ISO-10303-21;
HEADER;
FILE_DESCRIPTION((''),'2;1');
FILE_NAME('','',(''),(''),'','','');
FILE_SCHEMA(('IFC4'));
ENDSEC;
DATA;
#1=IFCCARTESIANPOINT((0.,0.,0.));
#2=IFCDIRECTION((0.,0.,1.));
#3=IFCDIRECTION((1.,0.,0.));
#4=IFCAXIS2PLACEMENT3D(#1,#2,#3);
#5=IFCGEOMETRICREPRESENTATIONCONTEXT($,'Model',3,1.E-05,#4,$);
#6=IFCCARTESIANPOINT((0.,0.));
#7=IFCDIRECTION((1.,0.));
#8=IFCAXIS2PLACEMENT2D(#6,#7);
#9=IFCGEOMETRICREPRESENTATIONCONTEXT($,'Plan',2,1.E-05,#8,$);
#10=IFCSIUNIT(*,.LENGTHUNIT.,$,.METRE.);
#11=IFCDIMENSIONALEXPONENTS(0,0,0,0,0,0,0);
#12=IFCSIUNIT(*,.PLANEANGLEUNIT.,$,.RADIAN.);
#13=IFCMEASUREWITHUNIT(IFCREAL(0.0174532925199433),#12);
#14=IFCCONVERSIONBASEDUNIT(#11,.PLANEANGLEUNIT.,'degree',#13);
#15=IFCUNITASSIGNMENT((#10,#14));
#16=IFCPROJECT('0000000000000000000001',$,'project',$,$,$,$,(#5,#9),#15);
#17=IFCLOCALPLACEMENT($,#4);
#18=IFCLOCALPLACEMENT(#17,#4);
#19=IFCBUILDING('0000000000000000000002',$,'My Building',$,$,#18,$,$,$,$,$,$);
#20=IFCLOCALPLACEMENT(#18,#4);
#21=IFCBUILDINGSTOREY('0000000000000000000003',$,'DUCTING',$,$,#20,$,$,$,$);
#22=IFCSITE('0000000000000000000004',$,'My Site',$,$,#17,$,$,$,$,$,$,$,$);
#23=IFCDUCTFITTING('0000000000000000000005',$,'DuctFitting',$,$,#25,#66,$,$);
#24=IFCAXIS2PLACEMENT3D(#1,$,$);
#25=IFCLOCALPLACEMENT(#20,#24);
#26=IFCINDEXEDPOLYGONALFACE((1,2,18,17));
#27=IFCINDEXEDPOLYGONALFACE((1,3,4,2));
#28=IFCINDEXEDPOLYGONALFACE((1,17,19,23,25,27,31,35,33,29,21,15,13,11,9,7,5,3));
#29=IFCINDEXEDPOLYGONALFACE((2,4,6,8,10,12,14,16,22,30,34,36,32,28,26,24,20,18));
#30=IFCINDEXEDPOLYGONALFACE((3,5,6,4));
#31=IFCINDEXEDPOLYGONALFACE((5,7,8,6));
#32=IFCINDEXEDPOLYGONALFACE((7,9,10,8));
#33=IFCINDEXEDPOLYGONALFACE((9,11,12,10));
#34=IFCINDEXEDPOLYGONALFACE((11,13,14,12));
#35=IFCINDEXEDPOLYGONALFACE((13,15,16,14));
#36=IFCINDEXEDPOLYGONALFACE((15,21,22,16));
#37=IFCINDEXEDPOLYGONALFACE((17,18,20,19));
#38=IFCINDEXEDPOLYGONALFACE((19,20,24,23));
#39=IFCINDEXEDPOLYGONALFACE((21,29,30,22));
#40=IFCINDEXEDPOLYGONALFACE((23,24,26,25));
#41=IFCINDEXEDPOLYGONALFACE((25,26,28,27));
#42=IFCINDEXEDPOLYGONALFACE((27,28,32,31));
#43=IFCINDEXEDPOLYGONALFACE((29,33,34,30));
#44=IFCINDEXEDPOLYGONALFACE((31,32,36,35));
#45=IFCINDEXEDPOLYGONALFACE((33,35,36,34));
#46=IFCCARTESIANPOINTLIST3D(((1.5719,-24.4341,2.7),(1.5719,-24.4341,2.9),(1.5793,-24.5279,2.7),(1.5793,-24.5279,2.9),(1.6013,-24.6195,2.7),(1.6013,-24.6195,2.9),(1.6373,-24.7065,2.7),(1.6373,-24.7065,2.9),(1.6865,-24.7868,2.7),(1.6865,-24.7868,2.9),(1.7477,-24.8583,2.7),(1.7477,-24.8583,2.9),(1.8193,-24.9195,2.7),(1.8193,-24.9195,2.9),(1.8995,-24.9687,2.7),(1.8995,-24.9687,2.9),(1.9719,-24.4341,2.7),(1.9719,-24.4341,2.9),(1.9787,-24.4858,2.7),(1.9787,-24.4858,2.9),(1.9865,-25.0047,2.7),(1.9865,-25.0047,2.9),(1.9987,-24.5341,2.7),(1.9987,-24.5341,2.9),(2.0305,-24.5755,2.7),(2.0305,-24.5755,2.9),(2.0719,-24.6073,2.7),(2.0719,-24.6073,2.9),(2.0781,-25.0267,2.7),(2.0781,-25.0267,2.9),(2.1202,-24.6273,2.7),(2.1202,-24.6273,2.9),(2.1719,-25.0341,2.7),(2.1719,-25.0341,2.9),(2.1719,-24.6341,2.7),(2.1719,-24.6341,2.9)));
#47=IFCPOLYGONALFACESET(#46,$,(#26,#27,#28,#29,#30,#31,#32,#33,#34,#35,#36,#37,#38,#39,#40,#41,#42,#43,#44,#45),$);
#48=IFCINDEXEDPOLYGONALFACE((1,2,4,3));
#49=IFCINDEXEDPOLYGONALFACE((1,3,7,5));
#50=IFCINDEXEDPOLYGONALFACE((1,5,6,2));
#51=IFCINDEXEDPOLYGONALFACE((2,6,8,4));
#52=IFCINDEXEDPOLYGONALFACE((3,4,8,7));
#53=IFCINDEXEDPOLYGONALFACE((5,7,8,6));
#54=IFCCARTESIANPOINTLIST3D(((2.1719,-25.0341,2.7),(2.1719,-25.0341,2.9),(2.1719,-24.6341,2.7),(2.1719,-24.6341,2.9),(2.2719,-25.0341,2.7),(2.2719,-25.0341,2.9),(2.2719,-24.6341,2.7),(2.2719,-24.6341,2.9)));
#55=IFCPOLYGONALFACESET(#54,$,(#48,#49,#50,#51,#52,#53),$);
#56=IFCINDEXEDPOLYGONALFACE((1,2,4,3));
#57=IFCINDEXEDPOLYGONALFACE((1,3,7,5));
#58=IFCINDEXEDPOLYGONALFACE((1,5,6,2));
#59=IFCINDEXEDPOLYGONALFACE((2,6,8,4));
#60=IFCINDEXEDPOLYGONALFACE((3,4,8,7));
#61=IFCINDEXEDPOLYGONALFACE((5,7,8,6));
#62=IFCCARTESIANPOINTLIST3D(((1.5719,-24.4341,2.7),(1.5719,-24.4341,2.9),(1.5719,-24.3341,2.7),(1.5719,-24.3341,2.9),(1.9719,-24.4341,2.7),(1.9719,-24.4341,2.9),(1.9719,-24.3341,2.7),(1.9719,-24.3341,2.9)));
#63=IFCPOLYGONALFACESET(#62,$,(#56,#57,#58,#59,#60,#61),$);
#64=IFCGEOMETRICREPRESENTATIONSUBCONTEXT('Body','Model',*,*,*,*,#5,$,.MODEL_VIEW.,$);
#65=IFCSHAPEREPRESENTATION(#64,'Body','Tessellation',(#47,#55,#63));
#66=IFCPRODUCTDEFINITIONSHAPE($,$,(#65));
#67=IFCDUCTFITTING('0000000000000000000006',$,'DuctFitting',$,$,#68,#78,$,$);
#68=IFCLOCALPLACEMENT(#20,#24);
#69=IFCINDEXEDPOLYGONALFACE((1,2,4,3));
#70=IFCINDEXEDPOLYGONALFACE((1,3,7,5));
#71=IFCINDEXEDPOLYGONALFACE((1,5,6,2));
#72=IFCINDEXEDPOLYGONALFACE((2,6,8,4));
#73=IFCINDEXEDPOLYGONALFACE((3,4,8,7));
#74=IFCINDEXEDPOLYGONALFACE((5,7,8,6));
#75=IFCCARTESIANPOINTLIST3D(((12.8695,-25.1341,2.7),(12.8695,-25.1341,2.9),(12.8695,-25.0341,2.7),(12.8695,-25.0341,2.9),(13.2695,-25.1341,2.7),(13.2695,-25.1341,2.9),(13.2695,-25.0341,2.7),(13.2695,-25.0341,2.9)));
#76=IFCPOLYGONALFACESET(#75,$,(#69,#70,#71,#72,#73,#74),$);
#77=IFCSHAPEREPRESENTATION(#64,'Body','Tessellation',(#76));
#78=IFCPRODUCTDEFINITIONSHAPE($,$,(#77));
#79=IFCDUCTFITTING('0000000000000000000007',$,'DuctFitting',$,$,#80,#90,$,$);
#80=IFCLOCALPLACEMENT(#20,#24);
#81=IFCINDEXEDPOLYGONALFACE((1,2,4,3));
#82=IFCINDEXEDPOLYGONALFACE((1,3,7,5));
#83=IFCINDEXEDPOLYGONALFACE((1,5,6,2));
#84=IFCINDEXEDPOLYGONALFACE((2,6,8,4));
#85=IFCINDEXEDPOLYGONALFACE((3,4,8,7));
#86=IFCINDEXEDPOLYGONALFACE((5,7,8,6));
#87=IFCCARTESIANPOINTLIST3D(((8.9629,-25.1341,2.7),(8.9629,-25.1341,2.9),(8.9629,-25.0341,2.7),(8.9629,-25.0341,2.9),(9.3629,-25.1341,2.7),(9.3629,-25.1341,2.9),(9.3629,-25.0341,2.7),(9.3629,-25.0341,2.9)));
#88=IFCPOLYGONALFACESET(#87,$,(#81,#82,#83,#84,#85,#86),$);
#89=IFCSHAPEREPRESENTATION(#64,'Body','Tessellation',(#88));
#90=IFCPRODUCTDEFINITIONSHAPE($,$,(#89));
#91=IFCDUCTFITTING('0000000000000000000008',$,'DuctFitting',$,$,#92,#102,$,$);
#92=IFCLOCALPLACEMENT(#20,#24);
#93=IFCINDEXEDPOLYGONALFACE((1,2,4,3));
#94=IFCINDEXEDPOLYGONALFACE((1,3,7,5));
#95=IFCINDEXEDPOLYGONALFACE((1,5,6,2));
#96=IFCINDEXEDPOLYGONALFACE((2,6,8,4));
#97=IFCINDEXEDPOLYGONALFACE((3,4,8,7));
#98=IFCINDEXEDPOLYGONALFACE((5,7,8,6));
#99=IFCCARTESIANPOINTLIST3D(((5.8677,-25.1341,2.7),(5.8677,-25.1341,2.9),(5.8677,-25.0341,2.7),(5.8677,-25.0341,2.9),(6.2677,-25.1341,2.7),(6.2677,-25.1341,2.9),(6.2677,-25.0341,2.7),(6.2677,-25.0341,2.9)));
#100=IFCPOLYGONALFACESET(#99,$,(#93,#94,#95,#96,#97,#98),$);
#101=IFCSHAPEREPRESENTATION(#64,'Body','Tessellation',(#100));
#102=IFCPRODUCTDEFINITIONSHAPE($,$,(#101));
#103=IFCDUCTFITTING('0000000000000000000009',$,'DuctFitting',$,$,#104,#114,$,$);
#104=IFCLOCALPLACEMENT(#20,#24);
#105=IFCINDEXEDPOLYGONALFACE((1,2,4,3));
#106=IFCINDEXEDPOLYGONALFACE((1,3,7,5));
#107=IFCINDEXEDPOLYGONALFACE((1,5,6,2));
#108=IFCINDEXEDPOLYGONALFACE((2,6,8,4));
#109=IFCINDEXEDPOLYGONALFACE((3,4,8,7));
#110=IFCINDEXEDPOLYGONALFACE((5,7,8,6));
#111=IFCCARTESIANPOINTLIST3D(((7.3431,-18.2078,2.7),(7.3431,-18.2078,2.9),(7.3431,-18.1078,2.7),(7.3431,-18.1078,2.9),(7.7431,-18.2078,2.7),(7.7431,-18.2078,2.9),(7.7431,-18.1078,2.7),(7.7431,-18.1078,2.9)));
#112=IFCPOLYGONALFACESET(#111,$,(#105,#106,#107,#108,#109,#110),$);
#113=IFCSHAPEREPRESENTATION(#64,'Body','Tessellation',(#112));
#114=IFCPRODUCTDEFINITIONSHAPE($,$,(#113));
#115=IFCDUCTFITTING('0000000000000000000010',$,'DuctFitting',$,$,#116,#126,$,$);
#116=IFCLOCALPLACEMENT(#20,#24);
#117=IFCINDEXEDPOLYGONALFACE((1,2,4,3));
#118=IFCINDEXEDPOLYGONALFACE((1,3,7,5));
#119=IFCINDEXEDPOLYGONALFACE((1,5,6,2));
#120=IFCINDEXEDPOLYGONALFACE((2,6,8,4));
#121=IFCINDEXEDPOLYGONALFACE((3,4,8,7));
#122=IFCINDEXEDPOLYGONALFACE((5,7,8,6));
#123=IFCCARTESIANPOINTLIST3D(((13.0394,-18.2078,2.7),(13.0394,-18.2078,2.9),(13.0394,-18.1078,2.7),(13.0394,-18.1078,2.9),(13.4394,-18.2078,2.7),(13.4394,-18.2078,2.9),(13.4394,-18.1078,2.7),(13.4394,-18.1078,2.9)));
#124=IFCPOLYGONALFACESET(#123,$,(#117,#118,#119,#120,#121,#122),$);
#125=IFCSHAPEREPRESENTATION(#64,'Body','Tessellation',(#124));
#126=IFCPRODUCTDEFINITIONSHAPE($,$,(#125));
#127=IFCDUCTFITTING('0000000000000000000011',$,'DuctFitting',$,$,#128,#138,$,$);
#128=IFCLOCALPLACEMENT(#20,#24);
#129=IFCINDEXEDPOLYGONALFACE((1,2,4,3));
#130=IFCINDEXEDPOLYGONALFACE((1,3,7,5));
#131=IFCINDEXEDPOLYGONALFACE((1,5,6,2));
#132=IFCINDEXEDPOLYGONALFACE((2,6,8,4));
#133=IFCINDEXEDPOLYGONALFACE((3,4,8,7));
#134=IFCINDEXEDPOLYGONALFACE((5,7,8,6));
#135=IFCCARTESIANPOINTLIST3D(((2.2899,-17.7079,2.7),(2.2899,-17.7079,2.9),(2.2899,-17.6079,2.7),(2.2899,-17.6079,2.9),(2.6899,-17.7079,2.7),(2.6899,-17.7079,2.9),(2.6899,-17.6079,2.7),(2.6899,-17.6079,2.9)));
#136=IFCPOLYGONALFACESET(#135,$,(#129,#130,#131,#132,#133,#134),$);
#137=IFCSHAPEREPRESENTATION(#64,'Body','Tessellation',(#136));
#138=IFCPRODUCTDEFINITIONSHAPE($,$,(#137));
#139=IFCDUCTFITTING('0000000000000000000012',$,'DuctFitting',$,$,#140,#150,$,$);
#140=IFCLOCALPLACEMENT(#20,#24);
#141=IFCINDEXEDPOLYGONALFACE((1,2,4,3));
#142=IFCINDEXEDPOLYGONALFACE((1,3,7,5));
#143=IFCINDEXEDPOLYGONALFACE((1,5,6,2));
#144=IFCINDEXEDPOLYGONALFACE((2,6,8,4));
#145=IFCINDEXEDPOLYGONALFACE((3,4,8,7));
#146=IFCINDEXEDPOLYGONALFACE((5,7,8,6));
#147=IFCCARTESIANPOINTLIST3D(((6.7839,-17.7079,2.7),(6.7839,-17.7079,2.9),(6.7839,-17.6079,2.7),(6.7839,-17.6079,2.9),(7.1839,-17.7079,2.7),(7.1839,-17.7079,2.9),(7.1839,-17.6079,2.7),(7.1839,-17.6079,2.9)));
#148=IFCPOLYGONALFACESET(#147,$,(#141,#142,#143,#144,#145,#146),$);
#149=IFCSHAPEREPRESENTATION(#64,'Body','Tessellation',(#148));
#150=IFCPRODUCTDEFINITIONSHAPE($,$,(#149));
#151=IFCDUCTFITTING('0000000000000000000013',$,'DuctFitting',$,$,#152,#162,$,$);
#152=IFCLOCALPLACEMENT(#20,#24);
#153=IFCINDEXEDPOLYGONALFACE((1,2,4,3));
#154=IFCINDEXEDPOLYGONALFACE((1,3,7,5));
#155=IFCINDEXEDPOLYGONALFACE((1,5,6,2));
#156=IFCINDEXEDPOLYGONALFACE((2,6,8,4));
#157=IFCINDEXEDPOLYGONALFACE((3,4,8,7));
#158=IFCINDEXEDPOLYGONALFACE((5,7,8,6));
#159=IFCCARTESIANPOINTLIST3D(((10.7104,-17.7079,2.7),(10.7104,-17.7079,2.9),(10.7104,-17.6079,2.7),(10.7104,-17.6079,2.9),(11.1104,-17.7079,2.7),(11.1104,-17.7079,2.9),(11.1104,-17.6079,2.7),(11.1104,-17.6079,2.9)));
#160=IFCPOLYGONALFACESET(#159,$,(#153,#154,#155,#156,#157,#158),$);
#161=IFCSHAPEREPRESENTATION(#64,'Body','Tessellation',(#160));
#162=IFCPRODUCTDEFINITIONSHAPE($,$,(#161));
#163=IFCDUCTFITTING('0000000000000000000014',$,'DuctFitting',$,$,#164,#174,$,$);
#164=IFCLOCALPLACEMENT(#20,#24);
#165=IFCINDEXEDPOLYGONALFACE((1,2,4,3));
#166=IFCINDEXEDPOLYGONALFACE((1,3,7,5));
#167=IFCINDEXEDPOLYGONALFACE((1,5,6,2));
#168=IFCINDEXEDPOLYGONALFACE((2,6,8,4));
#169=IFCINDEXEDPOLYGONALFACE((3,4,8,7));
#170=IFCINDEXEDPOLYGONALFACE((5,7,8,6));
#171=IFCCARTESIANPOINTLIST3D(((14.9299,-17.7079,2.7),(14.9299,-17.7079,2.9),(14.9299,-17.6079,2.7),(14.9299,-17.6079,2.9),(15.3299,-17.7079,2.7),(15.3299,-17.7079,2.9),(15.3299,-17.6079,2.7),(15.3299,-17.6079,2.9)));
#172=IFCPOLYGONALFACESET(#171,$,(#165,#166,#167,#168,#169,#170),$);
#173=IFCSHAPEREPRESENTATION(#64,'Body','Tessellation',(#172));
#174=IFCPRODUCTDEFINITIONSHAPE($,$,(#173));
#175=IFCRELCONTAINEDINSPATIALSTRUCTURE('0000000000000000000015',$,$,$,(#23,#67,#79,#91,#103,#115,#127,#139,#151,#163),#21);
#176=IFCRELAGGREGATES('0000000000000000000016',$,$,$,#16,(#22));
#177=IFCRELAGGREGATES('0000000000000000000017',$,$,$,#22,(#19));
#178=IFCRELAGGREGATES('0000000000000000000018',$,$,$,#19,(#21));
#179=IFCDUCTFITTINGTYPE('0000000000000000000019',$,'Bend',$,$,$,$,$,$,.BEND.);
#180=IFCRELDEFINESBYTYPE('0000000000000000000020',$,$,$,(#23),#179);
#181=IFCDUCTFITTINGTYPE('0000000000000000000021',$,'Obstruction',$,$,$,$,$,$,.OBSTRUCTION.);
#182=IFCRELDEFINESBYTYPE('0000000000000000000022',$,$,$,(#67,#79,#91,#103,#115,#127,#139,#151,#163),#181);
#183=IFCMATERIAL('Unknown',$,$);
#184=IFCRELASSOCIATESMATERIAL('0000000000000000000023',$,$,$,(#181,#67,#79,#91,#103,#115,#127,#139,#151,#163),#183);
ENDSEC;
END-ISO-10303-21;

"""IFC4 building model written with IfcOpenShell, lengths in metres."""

from ifc_helpers import new_model, entity, si_unit, converted_unit, frame, origin_with_axes, origin_2d_with_axis, place, context, subcontext, project, spatial, line, arc, indexed_curve, rectangle, outline, extrude, source, transform, mapped, material, material_profile, profile_set, profile_usage, type_object, type_shapes, element, save


model = new_model("IFC4")

# Units and contexts
model_context = context("Model", 3, precision=1e-05, world=origin_with_axes())
plan_context = context("Plan", 2, precision=1e-05, world=origin_2d_with_axis())
body_context = subcontext(model_context, "Body", "Model", "MODEL_VIEW")
ifc_project = project(units=[si_unit("LENGTHUNIT", "METRE"), converted_unit("PLANEANGLEUNIT", "degree", entity("IfcReal", 0.0174532925199433), si_unit("PLANEANGLEUNIT", "RADIAN"), dimensions=[0, 0, 0, 0, 0, 0, 0])], contexts=[model_context, plan_context])

# Site, building, storey
site_placement = place(None, origin_with_axes())
site = spatial("IfcSite", under=ifc_project, at=site_placement, Name="My Site")
building_placement = place(site_placement, origin_with_axes())
building = spatial("IfcBuilding", under=site, at=building_placement, Name="My Building")
storey_placement = place(building_placement, origin_with_axes())
storey = spatial("IfcBuildingStorey", under=building, at=storey_placement, Name="DUCTING")

# Shared definitions
ifc_material = material(Name="Unknown")

# Duct fittings
duct_fitting_type_1 = type_object("IfcDuctFittingType", Name="Bend", PredefinedType="BEND")
shared_shape = source(origin_with_axes(), body_context, "Body", "SweptSolid", [
    extrude(outline(indexed_curve([(-0.2, 0.0), (-0.2586, 0.1414), (-0.4, 0.2), (-0.4, 0.6), (0.0243, 0.4243), (0.2, 0.0)], segments=[arc(1, 2, 3), line(3, 4), arc(4, 5, 6), line(6, 1)])), frame((0.0, -0.1, 0.1), z_axis=(0.0, -1.0, 0.0), x_axis=(1.0, 0.0, 0.0)), (0.0, 0.0, -1.0), 0.2),
    extrude(rectangle(XDim=0.4, YDim=0.2), origin_with_axes(), (0.0, 0.0, 1.0), 0.1),
    extrude(rectangle(XDim=0.4, YDim=0.2), frame((-0.4, 0.0, 0.5), z_axis=(-1.0, 0.0, 0.0), x_axis=(0.0, 0.0, -1.0)), (0.0, 0.0, 1.0), 0.1),
])
type_shapes(duct_fitting_type_1, [shared_shape])
for number, where, z_axis, x_axis, name in (
    (1, (2.2719, -24.8341, 2.8), (-1.0, 0.0, 0.0), (0.0, -1.0, 0.0), "DuctFitting"),
):
    element("IfcDuctFitting", number, at=place(storey_placement, frame(where, z_axis=z_axis, x_axis=x_axis)), inside=storey, type_object=duct_fitting_type_1, Name=name, context=body_context, shape_type="MappedRepresentation", body=[
        mapped(shared_shape, transform((0.0, 0.0, 0.0), x_axis=(1.0, 0.0, 0.0), y_axis=(0.0, 1.0, 0.0), z_axis=(0.0, 0.0, 1.0), scale=1.0)),
    ])
ifc_material_profile_1 = material_profile(ifc_material, rectangle(XDim=0.4, YDim=0.2))
ifc_profile_set_1 = profile_set([ifc_material_profile_1])
ifc_profile_usage_1 = profile_usage(ifc_profile_set_1, cardinal=5)
duct_fitting_type_2 = type_object("IfcDuctFittingType", Name="Obstruction", PredefinedType="OBSTRUCTION", material=ifc_profile_set_1)
duct_fitting_1_placement = place(storey_placement, frame((13.0695, -25.1341, 2.8), z_axis=(0.0, 1.0, 0.0), x_axis=(-1.0, 0.0, 0.0)))
element("IfcDuctFitting", 2, at=duct_fitting_1_placement, inside=storey, type_object=duct_fitting_type_2, material=ifc_profile_usage_1, Name="DuctFitting", context=body_context, shape_type="SweptSolid", body=[
    extrude(rectangle(XDim=0.4, YDim=0.2), origin_with_axes(), (0.0, 0.0, 1.0), 0.1),
])
ifc_profile_usage_2 = profile_usage(ifc_profile_set_1, cardinal=5)
duct_fitting_2_placement = place(storey_placement, frame((9.1629, -25.1341, 2.8), z_axis=(0.0, 1.0, 0.0), x_axis=(-1.0, 0.0, 0.0)))
element("IfcDuctFitting", 3, at=duct_fitting_2_placement, inside=storey, type_object=duct_fitting_type_2, material=ifc_profile_usage_2, Name="DuctFitting", context=body_context, shape_type="SweptSolid", body=[
    extrude(rectangle(XDim=0.4, YDim=0.2), origin_with_axes(), (0.0, 0.0, 1.0), 0.1),
])
ifc_profile_usage_3 = profile_usage(ifc_profile_set_1, cardinal=5)
duct_fitting_3_placement = place(storey_placement, frame((6.0677, -25.1341, 2.8), z_axis=(0.0, 1.0, 0.0), x_axis=(-1.0, 0.0, 0.0)))
element("IfcDuctFitting", 4, at=duct_fitting_3_placement, inside=storey, type_object=duct_fitting_type_2, material=ifc_profile_usage_3, Name="DuctFitting", context=body_context, shape_type="SweptSolid", body=[
    extrude(rectangle(XDim=0.4, YDim=0.2), origin_with_axes(), (0.0, 0.0, 1.0), 0.1),
])
ifc_profile_usage_4 = profile_usage(ifc_profile_set_1, cardinal=5)
duct_fitting_4_placement = place(storey_placement, frame((7.5431, -18.2078, 2.8), z_axis=(0.0, 1.0, 0.0), x_axis=(-1.0, 0.0, 0.0)))
element("IfcDuctFitting", 5, at=duct_fitting_4_placement, inside=storey, type_object=duct_fitting_type_2, material=ifc_profile_usage_4, Name="DuctFitting", context=body_context, shape_type="SweptSolid", body=[
    extrude(rectangle(XDim=0.4, YDim=0.2), origin_with_axes(), (0.0, 0.0, 1.0), 0.1),
])
ifc_profile_usage_5 = profile_usage(ifc_profile_set_1, cardinal=5)
duct_fitting_5_placement = place(storey_placement, frame((13.2394, -18.2078, 2.8), z_axis=(0.0, 1.0, 0.0), x_axis=(-1.0, 0.0, 0.0)))
element("IfcDuctFitting", 6, at=duct_fitting_5_placement, inside=storey, type_object=duct_fitting_type_2, material=ifc_profile_usage_5, Name="DuctFitting", context=body_context, shape_type="SweptSolid", body=[
    extrude(rectangle(XDim=0.4, YDim=0.2), origin_with_axes(), (0.0, 0.0, 1.0), 0.1),
])
ifc_profile_usage_6 = profile_usage(ifc_profile_set_1, cardinal=5)
duct_fitting_6_placement = place(storey_placement, frame((2.4899, -17.6079, 2.8), z_axis=(0.0, -1.0, 0.0), x_axis=(1.0, 0.0, 0.0)))
element("IfcDuctFitting", 7, at=duct_fitting_6_placement, inside=storey, type_object=duct_fitting_type_2, material=ifc_profile_usage_6, Name="DuctFitting", context=body_context, shape_type="SweptSolid", body=[
    extrude(rectangle(XDim=0.4, YDim=0.2), origin_with_axes(), (0.0, 0.0, 1.0), 0.1),
])
ifc_profile_usage_7 = profile_usage(ifc_profile_set_1, cardinal=5)
duct_fitting_7_placement = place(storey_placement, frame((6.9839, -17.6079, 2.8), z_axis=(0.0, -1.0, 0.0), x_axis=(1.0, 0.0, 0.0)))
element("IfcDuctFitting", 8, at=duct_fitting_7_placement, inside=storey, type_object=duct_fitting_type_2, material=ifc_profile_usage_7, Name="DuctFitting", context=body_context, shape_type="SweptSolid", body=[
    extrude(rectangle(XDim=0.4, YDim=0.2), origin_with_axes(), (0.0, 0.0, 1.0), 0.1),
])
ifc_profile_usage_8 = profile_usage(ifc_profile_set_1, cardinal=5)
duct_fitting_8_placement = place(storey_placement, frame((10.9104, -17.6079, 2.8), z_axis=(0.0, -1.0, 0.0), x_axis=(1.0, 0.0, 0.0)))
element("IfcDuctFitting", 9, at=duct_fitting_8_placement, inside=storey, type_object=duct_fitting_type_2, material=ifc_profile_usage_8, Name="DuctFitting", context=body_context, shape_type="SweptSolid", body=[
    extrude(rectangle(XDim=0.4, YDim=0.2), origin_with_axes(), (0.0, 0.0, 1.0), 0.1),
])
ifc_profile_usage_9 = profile_usage(ifc_profile_set_1, cardinal=5)
duct_fitting_9_placement = place(storey_placement, frame((15.1299, -17.6079, 2.8), z_axis=(0.0, -1.0, 0.0), x_axis=(1.0, 0.0, 0.0)))
element("IfcDuctFitting", 10, at=duct_fitting_9_placement, inside=storey, type_object=duct_fitting_type_2, material=ifc_profile_usage_9, Name="DuctFitting", context=body_context, shape_type="SweptSolid", body=[
    extrude(rectangle(XDim=0.4, YDim=0.2), origin_with_axes(), (0.0, 0.0, 1.0), 0.1),
])

save(model, "model.ifc")
